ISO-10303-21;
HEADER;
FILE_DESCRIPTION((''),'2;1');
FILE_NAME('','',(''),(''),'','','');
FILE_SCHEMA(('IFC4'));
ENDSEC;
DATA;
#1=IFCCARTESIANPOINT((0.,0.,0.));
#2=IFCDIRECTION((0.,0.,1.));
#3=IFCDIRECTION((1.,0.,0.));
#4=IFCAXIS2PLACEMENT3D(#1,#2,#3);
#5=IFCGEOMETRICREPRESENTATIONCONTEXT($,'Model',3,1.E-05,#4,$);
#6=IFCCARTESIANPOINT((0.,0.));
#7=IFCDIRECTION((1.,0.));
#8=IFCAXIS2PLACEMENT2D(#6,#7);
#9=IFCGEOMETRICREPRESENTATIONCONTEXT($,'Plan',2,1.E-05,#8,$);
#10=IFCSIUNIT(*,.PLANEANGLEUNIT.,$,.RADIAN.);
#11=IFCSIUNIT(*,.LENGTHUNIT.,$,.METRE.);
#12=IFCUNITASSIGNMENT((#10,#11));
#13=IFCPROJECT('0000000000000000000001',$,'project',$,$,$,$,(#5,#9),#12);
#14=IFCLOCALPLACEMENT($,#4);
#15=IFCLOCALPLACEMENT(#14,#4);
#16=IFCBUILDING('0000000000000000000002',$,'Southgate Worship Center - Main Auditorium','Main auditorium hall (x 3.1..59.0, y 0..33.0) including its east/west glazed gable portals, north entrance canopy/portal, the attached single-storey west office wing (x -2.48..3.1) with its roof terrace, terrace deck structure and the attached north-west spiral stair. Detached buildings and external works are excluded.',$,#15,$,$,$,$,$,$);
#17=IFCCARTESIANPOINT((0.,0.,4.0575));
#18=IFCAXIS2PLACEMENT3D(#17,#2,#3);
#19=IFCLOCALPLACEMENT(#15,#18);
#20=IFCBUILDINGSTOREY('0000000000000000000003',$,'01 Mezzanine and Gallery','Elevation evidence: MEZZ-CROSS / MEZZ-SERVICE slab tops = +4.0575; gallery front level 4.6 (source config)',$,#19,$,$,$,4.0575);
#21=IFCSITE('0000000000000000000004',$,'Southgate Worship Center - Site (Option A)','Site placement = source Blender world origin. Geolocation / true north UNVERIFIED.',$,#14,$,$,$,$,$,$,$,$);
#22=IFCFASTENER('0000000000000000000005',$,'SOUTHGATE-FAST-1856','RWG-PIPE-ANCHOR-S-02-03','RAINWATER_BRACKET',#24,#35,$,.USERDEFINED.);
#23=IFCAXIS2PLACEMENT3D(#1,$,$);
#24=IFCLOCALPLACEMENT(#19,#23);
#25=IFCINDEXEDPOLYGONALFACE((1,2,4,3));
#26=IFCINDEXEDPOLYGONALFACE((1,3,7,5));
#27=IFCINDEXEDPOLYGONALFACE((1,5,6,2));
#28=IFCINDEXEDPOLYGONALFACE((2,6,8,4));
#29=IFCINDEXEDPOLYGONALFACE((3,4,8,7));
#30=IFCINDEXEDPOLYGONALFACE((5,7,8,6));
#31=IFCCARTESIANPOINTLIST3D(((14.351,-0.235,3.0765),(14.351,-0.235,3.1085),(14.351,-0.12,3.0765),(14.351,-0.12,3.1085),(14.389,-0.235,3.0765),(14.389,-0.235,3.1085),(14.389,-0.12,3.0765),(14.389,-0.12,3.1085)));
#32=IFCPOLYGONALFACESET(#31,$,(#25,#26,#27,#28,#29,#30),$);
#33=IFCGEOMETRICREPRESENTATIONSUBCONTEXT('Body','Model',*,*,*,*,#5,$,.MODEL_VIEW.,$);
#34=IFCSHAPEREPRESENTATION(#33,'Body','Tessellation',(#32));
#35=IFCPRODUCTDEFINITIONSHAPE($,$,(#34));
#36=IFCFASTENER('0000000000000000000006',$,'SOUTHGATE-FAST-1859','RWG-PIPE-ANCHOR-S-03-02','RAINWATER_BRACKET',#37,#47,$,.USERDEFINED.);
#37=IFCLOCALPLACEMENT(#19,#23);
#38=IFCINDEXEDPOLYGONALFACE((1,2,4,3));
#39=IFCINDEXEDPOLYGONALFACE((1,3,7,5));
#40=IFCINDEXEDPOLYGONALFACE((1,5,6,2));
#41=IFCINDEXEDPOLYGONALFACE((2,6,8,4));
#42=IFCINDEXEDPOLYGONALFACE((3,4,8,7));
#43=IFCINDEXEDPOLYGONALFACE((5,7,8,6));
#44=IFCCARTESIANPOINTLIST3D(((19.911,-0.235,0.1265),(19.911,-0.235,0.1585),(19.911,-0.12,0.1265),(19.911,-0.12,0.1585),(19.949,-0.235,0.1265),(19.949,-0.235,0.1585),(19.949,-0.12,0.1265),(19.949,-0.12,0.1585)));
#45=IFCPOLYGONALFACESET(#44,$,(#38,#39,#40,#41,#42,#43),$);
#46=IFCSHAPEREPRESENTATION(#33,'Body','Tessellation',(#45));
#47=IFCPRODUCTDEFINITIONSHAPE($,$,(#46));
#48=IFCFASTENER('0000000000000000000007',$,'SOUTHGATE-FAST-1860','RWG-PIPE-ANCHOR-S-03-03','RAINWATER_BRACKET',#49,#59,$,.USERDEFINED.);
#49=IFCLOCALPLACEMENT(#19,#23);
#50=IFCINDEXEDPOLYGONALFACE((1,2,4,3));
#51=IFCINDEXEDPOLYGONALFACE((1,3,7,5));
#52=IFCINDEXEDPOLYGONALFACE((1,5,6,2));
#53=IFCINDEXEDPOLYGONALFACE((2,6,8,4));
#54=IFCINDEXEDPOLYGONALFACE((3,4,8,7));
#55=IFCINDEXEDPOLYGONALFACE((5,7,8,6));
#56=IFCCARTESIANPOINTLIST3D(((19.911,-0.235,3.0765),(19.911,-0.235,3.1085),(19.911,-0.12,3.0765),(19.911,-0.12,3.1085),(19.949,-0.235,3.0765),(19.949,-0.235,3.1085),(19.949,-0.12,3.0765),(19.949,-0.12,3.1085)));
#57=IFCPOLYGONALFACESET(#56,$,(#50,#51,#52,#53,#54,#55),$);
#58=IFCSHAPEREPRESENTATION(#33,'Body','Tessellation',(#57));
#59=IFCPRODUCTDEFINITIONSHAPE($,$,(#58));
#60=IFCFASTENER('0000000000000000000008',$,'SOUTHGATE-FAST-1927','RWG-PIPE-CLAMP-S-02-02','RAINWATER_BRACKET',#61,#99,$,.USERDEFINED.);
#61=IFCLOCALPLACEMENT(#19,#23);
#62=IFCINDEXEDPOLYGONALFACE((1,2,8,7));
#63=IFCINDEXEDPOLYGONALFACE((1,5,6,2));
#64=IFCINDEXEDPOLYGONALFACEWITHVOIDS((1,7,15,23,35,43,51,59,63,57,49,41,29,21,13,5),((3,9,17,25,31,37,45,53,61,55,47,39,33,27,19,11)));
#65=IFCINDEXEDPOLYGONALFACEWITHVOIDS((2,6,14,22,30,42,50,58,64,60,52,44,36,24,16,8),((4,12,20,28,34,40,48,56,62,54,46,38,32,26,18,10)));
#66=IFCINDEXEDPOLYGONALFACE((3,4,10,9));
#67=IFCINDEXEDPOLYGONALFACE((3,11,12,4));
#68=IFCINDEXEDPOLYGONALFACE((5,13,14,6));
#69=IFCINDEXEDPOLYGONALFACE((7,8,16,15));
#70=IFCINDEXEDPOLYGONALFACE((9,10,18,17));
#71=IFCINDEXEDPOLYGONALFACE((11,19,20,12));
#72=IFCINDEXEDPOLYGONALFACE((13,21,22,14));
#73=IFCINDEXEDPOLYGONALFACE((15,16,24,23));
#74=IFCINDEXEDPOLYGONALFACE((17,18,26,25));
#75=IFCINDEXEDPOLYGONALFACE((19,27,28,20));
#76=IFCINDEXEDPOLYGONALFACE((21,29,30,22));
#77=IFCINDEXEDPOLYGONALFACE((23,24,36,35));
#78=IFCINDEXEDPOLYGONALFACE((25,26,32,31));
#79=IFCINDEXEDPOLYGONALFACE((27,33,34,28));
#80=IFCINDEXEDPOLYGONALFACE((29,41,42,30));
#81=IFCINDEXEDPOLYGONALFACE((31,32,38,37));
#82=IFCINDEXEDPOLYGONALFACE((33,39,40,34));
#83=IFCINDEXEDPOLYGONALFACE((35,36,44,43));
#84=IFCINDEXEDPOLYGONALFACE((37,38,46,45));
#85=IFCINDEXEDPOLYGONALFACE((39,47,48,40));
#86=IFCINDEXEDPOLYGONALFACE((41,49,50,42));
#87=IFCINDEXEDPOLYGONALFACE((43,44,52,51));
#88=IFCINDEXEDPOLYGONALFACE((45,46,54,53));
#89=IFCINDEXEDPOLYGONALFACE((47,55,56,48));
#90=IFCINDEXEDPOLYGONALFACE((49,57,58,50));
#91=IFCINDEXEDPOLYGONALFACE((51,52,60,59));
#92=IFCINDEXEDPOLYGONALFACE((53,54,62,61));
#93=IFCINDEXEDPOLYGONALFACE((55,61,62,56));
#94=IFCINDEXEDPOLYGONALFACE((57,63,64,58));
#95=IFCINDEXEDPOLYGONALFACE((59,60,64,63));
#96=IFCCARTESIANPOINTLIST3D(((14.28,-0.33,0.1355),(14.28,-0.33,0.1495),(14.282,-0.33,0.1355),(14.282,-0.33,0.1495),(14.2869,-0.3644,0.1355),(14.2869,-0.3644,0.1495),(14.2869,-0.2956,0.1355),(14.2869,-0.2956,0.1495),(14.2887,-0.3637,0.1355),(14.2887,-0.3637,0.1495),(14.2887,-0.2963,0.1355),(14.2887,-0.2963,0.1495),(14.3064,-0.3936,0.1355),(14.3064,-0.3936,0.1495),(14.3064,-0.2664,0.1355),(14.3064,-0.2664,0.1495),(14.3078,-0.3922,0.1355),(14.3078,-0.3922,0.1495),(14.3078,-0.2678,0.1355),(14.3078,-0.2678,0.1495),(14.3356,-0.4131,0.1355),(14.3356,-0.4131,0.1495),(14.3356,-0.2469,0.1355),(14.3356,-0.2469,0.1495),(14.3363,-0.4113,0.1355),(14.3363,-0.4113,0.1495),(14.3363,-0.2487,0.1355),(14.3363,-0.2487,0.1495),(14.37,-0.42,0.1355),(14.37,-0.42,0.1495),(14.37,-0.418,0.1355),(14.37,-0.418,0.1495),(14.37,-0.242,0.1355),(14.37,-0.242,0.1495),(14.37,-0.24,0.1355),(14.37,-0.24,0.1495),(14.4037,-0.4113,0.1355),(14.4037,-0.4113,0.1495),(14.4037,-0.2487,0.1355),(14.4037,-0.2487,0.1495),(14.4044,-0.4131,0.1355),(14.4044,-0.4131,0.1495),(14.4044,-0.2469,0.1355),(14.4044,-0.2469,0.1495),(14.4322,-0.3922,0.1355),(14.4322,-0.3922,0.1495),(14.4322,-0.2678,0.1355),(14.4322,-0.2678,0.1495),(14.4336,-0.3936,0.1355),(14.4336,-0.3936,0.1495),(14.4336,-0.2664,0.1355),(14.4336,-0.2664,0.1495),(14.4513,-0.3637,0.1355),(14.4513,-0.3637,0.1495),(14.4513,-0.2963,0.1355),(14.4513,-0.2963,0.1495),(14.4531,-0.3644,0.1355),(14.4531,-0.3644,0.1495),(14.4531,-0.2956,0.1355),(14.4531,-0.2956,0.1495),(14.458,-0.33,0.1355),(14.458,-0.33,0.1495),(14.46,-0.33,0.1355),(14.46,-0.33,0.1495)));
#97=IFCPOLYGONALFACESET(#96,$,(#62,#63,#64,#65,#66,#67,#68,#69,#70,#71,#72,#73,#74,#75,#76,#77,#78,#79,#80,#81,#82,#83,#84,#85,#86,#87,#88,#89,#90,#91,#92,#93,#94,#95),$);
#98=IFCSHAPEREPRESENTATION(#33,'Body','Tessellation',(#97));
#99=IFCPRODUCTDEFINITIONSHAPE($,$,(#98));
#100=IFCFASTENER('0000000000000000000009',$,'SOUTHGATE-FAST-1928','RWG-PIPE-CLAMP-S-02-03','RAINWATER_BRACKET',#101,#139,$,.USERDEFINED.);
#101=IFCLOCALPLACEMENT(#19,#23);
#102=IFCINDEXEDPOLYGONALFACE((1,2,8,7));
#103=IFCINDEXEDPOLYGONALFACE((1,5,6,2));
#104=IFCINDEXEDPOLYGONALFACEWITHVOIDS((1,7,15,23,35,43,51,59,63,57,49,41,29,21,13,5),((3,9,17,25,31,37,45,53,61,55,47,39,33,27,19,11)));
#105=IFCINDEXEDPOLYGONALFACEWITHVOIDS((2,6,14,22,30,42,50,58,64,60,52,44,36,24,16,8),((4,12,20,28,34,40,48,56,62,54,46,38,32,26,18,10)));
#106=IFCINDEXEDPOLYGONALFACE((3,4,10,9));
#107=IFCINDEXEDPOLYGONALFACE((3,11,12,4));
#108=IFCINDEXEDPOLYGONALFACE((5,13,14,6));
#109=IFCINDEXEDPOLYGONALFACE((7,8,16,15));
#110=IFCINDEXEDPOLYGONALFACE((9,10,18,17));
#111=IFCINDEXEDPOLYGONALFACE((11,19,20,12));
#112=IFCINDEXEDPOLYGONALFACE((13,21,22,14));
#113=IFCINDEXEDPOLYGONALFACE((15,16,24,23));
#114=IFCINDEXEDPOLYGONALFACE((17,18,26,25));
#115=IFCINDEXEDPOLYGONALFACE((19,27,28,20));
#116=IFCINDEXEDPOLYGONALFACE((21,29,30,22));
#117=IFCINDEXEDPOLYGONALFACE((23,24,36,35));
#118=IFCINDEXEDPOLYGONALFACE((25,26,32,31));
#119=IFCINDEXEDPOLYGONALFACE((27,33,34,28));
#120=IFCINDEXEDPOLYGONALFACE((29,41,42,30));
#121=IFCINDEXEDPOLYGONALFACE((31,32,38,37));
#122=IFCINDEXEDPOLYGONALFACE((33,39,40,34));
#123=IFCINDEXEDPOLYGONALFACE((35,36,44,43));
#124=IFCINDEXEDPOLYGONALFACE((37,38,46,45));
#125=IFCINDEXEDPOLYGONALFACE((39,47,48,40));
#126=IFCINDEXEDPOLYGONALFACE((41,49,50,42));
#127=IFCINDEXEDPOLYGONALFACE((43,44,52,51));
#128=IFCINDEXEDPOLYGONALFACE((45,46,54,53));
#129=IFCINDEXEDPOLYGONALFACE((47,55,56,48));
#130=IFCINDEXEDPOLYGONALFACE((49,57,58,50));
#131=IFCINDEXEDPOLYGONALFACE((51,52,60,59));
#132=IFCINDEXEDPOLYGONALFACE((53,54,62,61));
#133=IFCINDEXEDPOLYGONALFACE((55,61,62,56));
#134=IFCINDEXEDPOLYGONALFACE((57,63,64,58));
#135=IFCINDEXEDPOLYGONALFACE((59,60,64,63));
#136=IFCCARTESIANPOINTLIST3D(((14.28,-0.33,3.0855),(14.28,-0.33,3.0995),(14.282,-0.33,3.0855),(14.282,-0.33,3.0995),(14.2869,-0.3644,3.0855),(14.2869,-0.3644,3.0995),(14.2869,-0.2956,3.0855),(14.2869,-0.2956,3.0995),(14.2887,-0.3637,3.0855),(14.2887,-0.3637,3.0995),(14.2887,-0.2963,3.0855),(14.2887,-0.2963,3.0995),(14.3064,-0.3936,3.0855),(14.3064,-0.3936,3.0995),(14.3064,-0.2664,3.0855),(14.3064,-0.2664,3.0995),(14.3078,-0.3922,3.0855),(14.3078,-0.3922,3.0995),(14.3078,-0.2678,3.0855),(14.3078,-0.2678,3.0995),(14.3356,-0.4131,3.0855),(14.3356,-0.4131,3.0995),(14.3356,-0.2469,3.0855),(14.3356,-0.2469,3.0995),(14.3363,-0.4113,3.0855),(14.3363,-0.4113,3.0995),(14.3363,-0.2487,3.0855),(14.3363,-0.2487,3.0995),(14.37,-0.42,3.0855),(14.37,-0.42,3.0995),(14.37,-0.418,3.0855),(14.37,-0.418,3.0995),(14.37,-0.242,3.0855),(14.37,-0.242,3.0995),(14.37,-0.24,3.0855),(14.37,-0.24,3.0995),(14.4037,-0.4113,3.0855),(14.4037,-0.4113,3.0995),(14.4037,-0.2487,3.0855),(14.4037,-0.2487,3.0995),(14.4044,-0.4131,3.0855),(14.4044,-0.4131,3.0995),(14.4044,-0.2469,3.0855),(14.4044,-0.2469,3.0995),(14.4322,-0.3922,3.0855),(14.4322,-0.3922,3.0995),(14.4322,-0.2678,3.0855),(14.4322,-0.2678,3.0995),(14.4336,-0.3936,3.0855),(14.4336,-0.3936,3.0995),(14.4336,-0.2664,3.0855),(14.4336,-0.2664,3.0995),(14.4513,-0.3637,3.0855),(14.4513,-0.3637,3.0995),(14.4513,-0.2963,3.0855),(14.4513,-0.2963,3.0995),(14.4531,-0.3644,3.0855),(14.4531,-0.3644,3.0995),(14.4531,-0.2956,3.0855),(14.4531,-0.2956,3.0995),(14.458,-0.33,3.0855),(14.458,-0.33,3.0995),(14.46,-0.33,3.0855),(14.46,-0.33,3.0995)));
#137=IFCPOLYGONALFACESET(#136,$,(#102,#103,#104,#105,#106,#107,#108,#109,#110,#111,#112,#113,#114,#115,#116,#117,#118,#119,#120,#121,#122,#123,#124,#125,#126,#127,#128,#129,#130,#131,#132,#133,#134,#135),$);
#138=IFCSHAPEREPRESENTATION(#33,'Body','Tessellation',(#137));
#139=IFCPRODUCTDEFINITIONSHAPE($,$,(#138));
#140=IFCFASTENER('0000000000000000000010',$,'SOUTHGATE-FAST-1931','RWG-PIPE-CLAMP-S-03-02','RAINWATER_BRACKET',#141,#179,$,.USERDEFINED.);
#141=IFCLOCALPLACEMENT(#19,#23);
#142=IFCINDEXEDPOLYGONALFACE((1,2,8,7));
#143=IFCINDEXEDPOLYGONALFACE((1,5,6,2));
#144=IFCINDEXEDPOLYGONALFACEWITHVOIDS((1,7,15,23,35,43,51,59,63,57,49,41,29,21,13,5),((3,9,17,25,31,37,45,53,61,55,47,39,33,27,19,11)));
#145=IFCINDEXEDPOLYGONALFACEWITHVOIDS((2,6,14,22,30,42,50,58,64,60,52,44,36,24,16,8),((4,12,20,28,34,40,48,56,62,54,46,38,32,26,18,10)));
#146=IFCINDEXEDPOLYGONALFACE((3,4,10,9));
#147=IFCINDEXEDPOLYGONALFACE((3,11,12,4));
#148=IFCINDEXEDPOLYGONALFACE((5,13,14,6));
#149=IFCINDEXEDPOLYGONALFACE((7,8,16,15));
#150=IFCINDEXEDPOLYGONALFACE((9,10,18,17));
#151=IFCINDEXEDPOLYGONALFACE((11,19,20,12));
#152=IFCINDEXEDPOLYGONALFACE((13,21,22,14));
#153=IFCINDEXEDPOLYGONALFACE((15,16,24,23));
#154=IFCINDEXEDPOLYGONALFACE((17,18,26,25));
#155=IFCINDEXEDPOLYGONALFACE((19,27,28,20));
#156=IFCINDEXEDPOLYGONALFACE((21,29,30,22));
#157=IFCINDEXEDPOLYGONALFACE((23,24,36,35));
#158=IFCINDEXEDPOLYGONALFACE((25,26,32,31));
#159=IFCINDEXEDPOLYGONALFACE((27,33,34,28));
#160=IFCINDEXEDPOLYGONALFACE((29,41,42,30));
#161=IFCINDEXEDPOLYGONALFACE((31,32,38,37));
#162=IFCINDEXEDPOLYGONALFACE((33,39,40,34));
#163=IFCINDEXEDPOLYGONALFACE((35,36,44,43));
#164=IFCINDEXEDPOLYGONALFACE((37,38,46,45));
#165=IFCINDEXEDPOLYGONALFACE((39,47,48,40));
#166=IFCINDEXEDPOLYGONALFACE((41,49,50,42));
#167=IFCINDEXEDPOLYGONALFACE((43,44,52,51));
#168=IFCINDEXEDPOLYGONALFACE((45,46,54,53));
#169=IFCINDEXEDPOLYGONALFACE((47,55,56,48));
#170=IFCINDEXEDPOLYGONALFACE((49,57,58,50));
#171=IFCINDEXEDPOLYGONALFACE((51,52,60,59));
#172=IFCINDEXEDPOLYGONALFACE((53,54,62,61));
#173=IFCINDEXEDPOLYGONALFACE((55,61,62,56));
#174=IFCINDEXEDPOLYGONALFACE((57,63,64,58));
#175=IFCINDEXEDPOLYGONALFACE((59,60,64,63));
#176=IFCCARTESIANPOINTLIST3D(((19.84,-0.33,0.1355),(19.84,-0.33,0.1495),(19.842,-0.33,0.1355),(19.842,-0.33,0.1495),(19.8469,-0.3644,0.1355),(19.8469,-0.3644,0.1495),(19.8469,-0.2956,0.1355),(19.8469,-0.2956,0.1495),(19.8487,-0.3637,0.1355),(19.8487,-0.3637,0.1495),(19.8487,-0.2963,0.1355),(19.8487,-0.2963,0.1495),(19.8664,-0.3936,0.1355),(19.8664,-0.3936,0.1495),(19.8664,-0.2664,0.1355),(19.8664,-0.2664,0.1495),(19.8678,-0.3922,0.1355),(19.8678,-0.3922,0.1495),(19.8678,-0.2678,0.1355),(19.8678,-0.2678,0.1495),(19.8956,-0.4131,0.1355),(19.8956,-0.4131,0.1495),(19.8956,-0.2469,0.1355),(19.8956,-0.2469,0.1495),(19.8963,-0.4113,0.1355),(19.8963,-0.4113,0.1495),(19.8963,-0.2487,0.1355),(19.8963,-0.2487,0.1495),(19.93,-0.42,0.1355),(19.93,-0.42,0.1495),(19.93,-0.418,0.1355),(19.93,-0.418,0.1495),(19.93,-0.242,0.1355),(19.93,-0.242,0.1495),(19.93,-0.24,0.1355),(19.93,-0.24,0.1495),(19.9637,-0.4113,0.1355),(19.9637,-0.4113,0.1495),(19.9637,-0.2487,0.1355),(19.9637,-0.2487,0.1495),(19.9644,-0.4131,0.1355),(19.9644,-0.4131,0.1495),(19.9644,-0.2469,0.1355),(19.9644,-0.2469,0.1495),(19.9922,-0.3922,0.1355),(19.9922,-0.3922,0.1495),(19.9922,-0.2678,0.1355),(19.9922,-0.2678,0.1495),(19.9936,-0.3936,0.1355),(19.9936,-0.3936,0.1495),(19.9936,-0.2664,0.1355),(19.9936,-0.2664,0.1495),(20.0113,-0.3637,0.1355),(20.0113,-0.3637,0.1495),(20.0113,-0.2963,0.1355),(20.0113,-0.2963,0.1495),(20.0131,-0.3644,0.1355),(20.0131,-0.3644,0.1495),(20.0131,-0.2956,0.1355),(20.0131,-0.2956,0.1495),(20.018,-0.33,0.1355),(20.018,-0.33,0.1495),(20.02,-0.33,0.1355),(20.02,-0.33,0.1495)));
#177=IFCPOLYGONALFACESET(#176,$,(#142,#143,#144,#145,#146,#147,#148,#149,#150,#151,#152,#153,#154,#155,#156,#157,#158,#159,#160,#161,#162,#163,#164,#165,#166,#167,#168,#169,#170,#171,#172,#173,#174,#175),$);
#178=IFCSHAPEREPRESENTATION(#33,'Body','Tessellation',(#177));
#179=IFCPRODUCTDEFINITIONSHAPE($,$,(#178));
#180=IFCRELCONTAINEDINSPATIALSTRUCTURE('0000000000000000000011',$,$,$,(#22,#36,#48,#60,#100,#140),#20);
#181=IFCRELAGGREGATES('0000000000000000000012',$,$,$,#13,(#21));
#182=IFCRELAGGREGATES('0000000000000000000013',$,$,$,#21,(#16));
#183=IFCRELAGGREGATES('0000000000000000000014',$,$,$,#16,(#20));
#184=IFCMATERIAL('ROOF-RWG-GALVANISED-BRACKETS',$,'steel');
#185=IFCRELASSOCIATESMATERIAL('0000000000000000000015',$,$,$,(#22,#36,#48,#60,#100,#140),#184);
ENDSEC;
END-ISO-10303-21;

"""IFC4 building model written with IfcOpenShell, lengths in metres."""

from ifc_helpers import new_model, si_unit, frame, origin_with_axes, origin_2d, origin_2d_with_axis, place, context, subcontext, project, spatial, indexed_curve, rectangle, outline, extrude, material, element, save


model = new_model("IFC4")

# Units and contexts
model_context = context("Model", 3, precision=1e-05, world=origin_with_axes())
plan_context = context("Plan", 2, precision=1e-05, world=origin_2d_with_axis())
body_context = subcontext(model_context, "Body", "Model", "MODEL_VIEW")
ifc_project = project(units=[si_unit("PLANEANGLEUNIT", "RADIAN"), si_unit("LENGTHUNIT", "METRE")], contexts=[model_context, plan_context])

# Site, building, storey
site_placement = place(None, origin_with_axes())
site = spatial("IfcSite", under=ifc_project, at=site_placement, Name="Southgate Worship Center - Site (Option A)", Description="Site placement = source Blender world origin. Geolocation / true north UNVERIFIED.")
building_placement = place(site_placement, origin_with_axes())
building = spatial("IfcBuilding", under=site, at=building_placement, Name="Southgate Worship Center - Main Auditorium", Description="Main auditorium hall (x 3.1..59.0, y 0..33.0) including its east/west glazed gable portals, north entrance canopy/portal, the attached single-storey west office wing (x -2.48..3.1) with its roof terrace, terrace deck structure and the attached north-west spiral stair. Detached buildings and external works are excluded.")
storey_placement = place(building_placement, frame((0.0, 0.0, 4.0575), z_axis=(0.0, 0.0, 1.0), x_axis=(1.0, 0.0, 0.0)))
storey = spatial("IfcBuildingStorey", under=building, at=storey_placement, Name="01 Mezzanine and Gallery", Description="Elevation evidence: MEZZ-CROSS / MEZZ-SERVICE slab tops = +4.0575; gallery front level 4.6 (source config)", Elevation=4.0575)

# Fasteners
ifc_material_1 = material(Name="ROOF-RWG-GALVANISED-BRACKETS", Category="steel")
fastener_1_placement = place(storey_placement, frame((14.351, -0.235, 3.0765), z_axis=(0.0, 0.0, 1.0), x_axis=(1.0, 0.0, 0.0)))
element("IfcFastener", 1, at=fastener_1_placement, inside=storey, material=ifc_material_1, Name="SOUTHGATE-FAST-1856", Description="RWG-PIPE-ANCHOR-S-02-03", ObjectType="RAINWATER_BRACKET", PredefinedType="USERDEFINED", context=body_context, shape_type="SweptSolid", body=[
    extrude(rectangle(XDim=0.038, YDim=0.115, at=origin_2d()), frame((0.019, 0.0575, 0.0), z_axis=(0.0, 0.0, 1.0), x_axis=(1.0, 0.0, 0.0)), (0.0, 0.0, 1.0), 0.032),
])
fastener_2_placement = place(storey_placement, frame((19.911, -0.235, 0.1265), z_axis=(0.0, 0.0, 1.0), x_axis=(1.0, 0.0, 0.0)))
element("IfcFastener", 2, at=fastener_2_placement, inside=storey, material=ifc_material_1, Name="SOUTHGATE-FAST-1859", Description="RWG-PIPE-ANCHOR-S-03-02", ObjectType="RAINWATER_BRACKET", PredefinedType="USERDEFINED", context=body_context, shape_type="SweptSolid", body=[
    extrude(rectangle(XDim=0.038, YDim=0.115, at=origin_2d()), frame((0.019, 0.0575, 0.0), z_axis=(0.0, 0.0, 1.0), x_axis=(1.0, 0.0, 0.0)), (0.0, 0.0, 1.0), 0.032),
])
fastener_3_placement = place(storey_placement, frame((19.911, -0.235, 3.0765), z_axis=(0.0, 0.0, 1.0), x_axis=(1.0, 0.0, 0.0)))
element("IfcFastener", 3, at=fastener_3_placement, inside=storey, material=ifc_material_1, Name="SOUTHGATE-FAST-1860", Description="RWG-PIPE-ANCHOR-S-03-03", ObjectType="RAINWATER_BRACKET", PredefinedType="USERDEFINED", context=body_context, shape_type="SweptSolid", body=[
    extrude(rectangle(XDim=0.038, YDim=0.115, at=origin_2d()), frame((0.019, 0.0575, 0.0), z_axis=(0.0, 0.0, 1.0), x_axis=(1.0, 0.0, 0.0)), (0.0, 0.0, 1.0), 0.032),
])
fastener_4_placement = place(storey_placement, frame((14.28, -0.42, 0.1355), z_axis=(0.0, 0.0, 1.0), x_axis=(1.0, 0.0, 0.0)))
element("IfcFastener", 4, at=fastener_4_placement, inside=storey, material=ifc_material_1, Name="SOUTHGATE-FAST-1927", Description="RWG-PIPE-CLAMP-S-02-02", ObjectType="RAINWATER_BRACKET", PredefinedType="USERDEFINED", context=body_context, shape_type="SweptSolid", body=[
    extrude(outline(indexed_curve([(0.0, 0.0), (0.0069, 0.0344), (0.0, 0.0689), (-0.0195, 0.0981), (-0.0487, 0.1176), (-0.0831, 0.1244), (-0.1176, 0.1176), (-0.1468, 0.0981), (-0.1663, 0.0689), (-0.1731, 0.0344), (-0.1663, 0.0), (-0.1468, -0.0292), (-0.1176, -0.0487), (-0.0831, -0.0556), (-0.0487, -0.0487), (-0.0195, -0.0292), (0.0, 0.0)], self_intersect=False), holes=[indexed_curve([(-0.1454, -0.0278), (-0.1644, 0.0008), (-0.1711, 0.0344), (-0.1644, 0.0681), (-0.1454, 0.0967), (-0.1168, 0.1157), (-0.0831, 0.1224), (-0.0495, 0.1157), (-0.0209, 0.0967), (-0.0018, 0.0681), (0.0049, 0.0344), (-0.0018, 0.0008), (-0.0209, -0.0278), (-0.0495, -0.0469), (-0.0831, -0.0536), (-0.1168, -0.0469), (-0.1454, -0.0278)], self_intersect=False)]), frame((0.1731, 0.0556, 0.0), z_axis=(0.0, 0.0, 1.0), x_axis=(1.0, 0.0, 0.0)), (0.0, 0.0, 1.0), 0.014),
])
fastener_5_placement = place(storey_placement, frame((14.28, -0.42, 3.0855), z_axis=(0.0, 0.0, 1.0), x_axis=(1.0, 0.0, 0.0)))
element("IfcFastener", 5, at=fastener_5_placement, inside=storey, material=ifc_material_1, Name="SOUTHGATE-FAST-1928", Description="RWG-PIPE-CLAMP-S-02-03", ObjectType="RAINWATER_BRACKET", PredefinedType="USERDEFINED", context=body_context, shape_type="SweptSolid", body=[
    extrude(outline(indexed_curve([(0.0, 0.0), (0.0069, 0.0344), (0.0, 0.0689), (-0.0195, 0.0981), (-0.0487, 0.1176), (-0.0831, 0.1244), (-0.1176, 0.1176), (-0.1468, 0.0981), (-0.1663, 0.0689), (-0.1731, 0.0344), (-0.1663, 0.0), (-0.1468, -0.0292), (-0.1176, -0.0487), (-0.0831, -0.0556), (-0.0487, -0.0487), (-0.0195, -0.0292), (0.0, 0.0)], self_intersect=False), holes=[indexed_curve([(-0.1454, -0.0278), (-0.1644, 0.0008), (-0.1711, 0.0344), (-0.1644, 0.0681), (-0.1454, 0.0967), (-0.1168, 0.1157), (-0.0831, 0.1224), (-0.0495, 0.1157), (-0.0209, 0.0967), (-0.0018, 0.0681), (0.0049, 0.0344), (-0.0018, 0.0008), (-0.0209, -0.0278), (-0.0495, -0.0469), (-0.0831, -0.0536), (-0.1168, -0.0469), (-0.1454, -0.0278)], self_intersect=False)]), frame((0.1731, 0.0556, 0.0), z_axis=(0.0, 0.0, 1.0), x_axis=(1.0, 0.0, 0.0)), (0.0, 0.0, 1.0), 0.014),
])
fastener_6_placement = place(storey_placement, frame((19.84, -0.42, 0.1355), z_axis=(0.0, 0.0, 1.0), x_axis=(1.0, 0.0, 0.0)))
element("IfcFastener", 6, at=fastener_6_placement, inside=storey, material=ifc_material_1, Name="SOUTHGATE-FAST-1931", Description="RWG-PIPE-CLAMP-S-03-02", ObjectType="RAINWATER_BRACKET", PredefinedType="USERDEFINED", context=body_context, shape_type="SweptSolid", body=[
    extrude(outline(indexed_curve([(0.0, 0.0), (0.0069, 0.0344), (0.0, 0.0689), (-0.0195, 0.0981), (-0.0487, 0.1176), (-0.0831, 0.1244), (-0.1176, 0.1176), (-0.1468, 0.0981), (-0.1663, 0.0689), (-0.1731, 0.0344), (-0.1663, 0.0), (-0.1468, -0.0292), (-0.1176, -0.0487), (-0.0831, -0.0556), (-0.0487, -0.0487), (-0.0195, -0.0292), (0.0, 0.0)], self_intersect=False), holes=[indexed_curve([(-0.1454, -0.0278), (-0.1644, 0.0008), (-0.1711, 0.0344), (-0.1644, 0.0681), (-0.1454, 0.0967), (-0.1168, 0.1157), (-0.0831, 0.1224), (-0.0495, 0.1157), (-0.0209, 0.0967), (-0.0018, 0.0681), (0.0049, 0.0344), (-0.0018, 0.0008), (-0.0209, -0.0278), (-0.0495, -0.0469), (-0.0831, -0.0536), (-0.1168, -0.0469), (-0.1454, -0.0278)], self_intersect=False)]), frame((0.1731, 0.0556, 0.0), z_axis=(0.0, 0.0, 1.0), x_axis=(1.0, 0.0, 0.0)), (0.0, 0.0, 1.0), 0.014),
])

save(model, "model.ifc")
